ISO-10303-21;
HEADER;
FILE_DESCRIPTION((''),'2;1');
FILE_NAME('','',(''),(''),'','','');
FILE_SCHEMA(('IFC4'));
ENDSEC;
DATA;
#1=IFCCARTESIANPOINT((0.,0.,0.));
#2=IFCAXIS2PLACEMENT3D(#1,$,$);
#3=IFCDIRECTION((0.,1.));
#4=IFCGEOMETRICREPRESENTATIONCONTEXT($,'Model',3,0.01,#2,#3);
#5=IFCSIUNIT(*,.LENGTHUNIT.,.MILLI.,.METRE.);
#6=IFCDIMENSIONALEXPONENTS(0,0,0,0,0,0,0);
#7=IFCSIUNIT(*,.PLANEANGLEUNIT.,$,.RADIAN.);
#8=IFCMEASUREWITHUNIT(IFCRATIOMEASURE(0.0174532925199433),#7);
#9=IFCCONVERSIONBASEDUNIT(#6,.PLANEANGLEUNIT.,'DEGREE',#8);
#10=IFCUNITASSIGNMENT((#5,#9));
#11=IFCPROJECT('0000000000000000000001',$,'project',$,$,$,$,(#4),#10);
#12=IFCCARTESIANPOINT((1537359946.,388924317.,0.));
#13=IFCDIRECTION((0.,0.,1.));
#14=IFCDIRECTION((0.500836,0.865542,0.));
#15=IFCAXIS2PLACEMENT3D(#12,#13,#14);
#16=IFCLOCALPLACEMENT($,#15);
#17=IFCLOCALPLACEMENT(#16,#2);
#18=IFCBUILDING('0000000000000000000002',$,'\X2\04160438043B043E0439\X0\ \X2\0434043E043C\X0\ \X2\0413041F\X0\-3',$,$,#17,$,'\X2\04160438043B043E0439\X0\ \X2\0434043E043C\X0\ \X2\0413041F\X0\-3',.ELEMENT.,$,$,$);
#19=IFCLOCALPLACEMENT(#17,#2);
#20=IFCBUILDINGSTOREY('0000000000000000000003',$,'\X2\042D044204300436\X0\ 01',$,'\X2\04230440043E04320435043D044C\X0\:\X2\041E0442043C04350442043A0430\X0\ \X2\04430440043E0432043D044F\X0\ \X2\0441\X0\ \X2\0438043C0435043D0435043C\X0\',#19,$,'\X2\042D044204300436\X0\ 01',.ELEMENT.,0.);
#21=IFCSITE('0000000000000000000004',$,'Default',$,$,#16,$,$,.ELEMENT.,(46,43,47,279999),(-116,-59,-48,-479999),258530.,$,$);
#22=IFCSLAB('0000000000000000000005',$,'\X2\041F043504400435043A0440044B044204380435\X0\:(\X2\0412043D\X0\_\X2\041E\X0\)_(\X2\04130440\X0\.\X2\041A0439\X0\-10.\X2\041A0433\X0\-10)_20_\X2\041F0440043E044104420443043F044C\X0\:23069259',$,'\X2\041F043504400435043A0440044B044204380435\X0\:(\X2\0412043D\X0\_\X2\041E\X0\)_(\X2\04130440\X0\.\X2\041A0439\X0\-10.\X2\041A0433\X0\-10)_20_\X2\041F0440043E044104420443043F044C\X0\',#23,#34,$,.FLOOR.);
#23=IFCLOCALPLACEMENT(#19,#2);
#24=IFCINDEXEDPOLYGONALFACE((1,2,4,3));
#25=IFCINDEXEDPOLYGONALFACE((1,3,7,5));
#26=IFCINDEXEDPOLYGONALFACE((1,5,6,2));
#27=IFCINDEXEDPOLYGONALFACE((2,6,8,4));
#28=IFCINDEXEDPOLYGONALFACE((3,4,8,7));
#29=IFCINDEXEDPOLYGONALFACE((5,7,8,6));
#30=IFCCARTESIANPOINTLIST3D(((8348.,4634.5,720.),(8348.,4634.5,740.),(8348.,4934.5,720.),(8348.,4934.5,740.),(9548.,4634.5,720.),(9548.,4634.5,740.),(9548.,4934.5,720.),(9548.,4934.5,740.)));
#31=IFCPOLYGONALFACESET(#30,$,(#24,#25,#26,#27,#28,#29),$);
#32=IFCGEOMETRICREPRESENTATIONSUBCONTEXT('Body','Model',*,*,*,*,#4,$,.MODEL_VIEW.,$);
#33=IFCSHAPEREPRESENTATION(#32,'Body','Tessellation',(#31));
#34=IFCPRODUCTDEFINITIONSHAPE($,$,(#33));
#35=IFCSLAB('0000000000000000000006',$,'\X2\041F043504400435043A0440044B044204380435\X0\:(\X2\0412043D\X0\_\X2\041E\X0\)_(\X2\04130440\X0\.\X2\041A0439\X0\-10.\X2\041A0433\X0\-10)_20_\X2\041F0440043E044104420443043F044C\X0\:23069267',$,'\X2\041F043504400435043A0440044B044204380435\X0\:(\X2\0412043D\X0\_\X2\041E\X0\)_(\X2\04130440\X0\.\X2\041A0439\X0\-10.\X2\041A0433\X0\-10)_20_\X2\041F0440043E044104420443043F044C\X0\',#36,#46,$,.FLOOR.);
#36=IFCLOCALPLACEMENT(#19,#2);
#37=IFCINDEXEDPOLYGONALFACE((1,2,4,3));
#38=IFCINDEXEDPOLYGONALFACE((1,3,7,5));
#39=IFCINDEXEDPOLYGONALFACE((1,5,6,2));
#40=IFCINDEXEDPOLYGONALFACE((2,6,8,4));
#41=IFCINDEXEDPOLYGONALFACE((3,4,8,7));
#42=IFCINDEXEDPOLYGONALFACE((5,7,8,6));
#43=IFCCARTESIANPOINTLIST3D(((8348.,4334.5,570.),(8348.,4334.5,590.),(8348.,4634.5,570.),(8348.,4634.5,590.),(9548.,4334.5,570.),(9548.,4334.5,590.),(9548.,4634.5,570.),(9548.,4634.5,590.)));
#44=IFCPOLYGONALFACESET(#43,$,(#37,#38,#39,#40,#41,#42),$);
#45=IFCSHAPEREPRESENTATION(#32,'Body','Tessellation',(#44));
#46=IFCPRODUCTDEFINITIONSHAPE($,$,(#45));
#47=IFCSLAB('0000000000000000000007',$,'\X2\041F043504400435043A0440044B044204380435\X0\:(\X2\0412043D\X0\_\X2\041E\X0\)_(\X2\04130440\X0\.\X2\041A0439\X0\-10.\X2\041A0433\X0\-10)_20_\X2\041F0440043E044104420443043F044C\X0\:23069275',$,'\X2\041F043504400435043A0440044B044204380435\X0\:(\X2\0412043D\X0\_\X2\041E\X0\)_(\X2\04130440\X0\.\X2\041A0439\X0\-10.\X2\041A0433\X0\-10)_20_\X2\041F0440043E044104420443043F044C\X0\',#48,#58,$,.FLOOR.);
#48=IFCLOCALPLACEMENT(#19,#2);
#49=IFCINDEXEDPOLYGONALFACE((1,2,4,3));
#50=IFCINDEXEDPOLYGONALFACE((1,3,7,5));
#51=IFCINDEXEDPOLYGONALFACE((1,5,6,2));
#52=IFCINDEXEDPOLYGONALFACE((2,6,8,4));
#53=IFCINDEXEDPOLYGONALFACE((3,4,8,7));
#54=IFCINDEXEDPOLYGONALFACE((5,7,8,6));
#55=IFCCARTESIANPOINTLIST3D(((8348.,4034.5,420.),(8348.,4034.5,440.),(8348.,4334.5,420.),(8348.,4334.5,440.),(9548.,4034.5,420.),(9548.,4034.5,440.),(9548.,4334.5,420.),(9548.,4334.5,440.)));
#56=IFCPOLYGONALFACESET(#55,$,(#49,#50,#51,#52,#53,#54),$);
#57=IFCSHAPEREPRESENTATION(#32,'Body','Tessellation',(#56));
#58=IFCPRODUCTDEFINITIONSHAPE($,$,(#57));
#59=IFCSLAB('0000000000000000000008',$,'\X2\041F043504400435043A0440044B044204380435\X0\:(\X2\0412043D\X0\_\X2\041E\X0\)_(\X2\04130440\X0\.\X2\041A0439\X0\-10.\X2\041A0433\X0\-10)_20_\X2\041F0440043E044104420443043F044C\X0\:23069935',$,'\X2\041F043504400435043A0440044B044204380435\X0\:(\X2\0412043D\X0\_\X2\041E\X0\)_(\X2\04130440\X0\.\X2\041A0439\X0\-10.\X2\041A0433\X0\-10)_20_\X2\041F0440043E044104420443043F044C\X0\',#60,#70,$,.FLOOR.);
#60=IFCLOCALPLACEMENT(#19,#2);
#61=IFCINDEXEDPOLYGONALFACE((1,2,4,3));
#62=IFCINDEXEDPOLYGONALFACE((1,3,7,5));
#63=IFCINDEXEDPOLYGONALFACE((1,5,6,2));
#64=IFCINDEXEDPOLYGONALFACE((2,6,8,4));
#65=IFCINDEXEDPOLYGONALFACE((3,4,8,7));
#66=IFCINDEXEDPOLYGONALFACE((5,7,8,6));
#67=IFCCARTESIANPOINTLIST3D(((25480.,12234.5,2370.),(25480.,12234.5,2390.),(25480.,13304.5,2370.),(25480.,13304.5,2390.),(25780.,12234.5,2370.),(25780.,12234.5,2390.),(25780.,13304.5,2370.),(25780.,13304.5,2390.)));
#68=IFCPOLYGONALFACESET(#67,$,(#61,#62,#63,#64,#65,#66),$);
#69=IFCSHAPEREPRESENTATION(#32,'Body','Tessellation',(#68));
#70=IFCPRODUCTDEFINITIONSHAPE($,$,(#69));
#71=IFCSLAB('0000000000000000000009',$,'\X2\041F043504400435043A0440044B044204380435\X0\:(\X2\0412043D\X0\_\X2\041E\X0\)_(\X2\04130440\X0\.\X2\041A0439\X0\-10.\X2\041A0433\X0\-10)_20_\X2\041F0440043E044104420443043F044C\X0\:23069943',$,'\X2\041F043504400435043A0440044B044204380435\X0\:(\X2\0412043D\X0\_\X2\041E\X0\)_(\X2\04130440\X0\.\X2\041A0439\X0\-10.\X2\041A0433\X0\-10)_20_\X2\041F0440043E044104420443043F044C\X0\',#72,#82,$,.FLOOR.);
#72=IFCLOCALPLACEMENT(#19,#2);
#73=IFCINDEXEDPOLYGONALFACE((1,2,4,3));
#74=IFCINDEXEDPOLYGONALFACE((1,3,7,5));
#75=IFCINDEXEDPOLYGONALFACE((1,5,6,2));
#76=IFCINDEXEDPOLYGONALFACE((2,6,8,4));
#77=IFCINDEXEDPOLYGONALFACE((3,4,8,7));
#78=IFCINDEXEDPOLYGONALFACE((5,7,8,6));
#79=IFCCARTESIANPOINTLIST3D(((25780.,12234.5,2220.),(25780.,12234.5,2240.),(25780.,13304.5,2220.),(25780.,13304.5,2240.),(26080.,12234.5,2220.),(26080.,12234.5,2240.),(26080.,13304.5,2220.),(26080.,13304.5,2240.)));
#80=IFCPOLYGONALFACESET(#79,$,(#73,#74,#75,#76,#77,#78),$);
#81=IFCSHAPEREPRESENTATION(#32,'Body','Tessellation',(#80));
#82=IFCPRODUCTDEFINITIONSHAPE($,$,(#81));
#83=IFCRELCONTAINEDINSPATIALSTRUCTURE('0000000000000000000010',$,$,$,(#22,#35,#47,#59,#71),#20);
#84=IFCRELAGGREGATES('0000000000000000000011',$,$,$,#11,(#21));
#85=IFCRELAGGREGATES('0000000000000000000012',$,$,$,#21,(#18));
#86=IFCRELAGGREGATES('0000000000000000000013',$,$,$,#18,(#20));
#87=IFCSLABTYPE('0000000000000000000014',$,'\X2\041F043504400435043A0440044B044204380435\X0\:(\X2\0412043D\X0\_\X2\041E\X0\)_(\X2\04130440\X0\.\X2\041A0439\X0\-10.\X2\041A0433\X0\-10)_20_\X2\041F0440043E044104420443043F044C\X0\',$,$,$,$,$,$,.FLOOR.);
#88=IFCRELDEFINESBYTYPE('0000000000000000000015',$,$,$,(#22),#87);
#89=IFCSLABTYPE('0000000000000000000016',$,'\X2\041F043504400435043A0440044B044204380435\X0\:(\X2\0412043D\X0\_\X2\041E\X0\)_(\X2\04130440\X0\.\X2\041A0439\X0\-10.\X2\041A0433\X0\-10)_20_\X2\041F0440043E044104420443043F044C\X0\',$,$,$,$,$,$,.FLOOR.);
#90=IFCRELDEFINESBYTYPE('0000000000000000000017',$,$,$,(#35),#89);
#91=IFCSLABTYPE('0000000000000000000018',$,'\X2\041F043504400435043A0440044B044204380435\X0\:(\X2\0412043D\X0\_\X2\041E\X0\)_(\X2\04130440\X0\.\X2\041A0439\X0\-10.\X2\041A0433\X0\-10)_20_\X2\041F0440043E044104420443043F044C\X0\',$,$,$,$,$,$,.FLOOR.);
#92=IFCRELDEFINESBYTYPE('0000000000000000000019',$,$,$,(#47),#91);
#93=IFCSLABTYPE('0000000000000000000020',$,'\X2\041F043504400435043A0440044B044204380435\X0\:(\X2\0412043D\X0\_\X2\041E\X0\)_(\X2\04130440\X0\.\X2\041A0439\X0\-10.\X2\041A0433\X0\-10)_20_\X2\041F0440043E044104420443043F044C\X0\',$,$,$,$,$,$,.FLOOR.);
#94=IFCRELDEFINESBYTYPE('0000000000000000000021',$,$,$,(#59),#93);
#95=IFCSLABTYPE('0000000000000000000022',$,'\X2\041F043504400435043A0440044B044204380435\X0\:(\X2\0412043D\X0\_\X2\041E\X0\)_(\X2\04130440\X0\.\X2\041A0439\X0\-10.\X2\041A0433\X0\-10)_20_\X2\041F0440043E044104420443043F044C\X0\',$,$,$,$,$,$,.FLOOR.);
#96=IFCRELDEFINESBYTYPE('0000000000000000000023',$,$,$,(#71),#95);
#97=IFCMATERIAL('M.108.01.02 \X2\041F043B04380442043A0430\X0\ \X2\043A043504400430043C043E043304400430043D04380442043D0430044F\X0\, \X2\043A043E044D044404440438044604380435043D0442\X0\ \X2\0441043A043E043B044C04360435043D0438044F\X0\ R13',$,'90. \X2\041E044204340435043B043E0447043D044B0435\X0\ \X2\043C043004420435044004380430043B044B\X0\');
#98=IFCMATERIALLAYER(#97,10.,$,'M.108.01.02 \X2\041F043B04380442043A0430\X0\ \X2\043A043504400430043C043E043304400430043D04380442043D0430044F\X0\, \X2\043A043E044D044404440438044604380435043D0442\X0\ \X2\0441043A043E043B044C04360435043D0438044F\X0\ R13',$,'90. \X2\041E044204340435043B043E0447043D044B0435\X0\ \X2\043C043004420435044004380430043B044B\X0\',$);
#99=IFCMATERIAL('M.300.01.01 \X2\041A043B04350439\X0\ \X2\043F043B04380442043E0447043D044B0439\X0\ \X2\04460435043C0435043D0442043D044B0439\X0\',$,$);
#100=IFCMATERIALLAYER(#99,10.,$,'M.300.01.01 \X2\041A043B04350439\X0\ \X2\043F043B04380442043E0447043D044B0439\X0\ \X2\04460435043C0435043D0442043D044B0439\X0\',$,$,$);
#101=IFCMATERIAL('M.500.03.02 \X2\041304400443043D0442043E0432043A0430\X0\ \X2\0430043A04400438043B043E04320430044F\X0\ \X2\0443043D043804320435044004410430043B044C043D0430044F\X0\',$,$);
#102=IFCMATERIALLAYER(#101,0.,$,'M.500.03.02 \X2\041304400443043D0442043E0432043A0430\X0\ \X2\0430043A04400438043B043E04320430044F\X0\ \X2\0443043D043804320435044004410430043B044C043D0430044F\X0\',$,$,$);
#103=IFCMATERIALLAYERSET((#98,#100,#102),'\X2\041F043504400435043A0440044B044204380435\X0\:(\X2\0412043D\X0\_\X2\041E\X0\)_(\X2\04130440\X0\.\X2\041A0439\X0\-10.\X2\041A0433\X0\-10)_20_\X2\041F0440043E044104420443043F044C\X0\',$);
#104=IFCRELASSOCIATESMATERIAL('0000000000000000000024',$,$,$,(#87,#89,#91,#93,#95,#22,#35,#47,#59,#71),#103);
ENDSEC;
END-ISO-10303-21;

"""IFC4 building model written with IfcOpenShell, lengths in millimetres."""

from ifc_helpers import new_model, entity, si_unit, converted_unit, direction, frame, frame_2d, origin, origin_2d_with_axis, place, context, subcontext, project, spatial, rectangle, extrude, material, layer, layer_set, layer_usage, type_object, element, save


model = new_model("IFC4")

# Units and contexts
model_context = context("Model", 3, precision=0.01, world=origin(), true_north=direction((0.0, 1.0)))
body_context = subcontext(model_context, "Body", "Model", "MODEL_VIEW")
ifc_project = project(units=[si_unit("LENGTHUNIT", "METRE", prefix="MILLI"), converted_unit("PLANEANGLEUNIT", "DEGREE", entity("IfcRatioMeasure", 0.0174532925199433), si_unit("PLANEANGLEUNIT", "RADIAN"), dimensions=[0, 0, 0, 0, 0, 0, 0])], contexts=[model_context])

# Site, building, storey
site_placement = place(None, frame((1537359946.0, 388924317.0, 0.0), z_axis=(0.0, 0.0, 1.0), x_axis=(0.500836, 0.865542, 0.0)))
site = spatial("IfcSite", under=ifc_project, at=site_placement, Name="Default", CompositionType="ELEMENT", RefLatitude=(46, 43, 47, 279999), RefLongitude=(-116, -59, -48, -479999), RefElevation=258530.0)
building_placement = place(site_placement, origin())
building = spatial("IfcBuilding", under=site, at=building_placement, Name="Жилой дом ГП-3", LongName="Жилой дом ГП-3", CompositionType="ELEMENT")
storey_placement = place(building_placement, origin())
storey = spatial("IfcBuildingStorey", under=building, at=storey_placement, Name="Этаж 01", ObjectType="Уровень:Отметка уровня с именем", LongName="Этаж 01", CompositionType="ELEMENT", Elevation=0.0)

# Slabs
ifc_material_1 = material(Name="M.108.01.02 Плитка керамогранитная, коэффициент скольжения R13", Category="90. Отделочные материалы")
ifc_layer_1 = layer(ifc_material_1, 10.0, Name="M.108.01.02 Плитка керамогранитная, коэффициент скольжения R13", Category="90. Отделочные материалы")
ifc_material_2 = material(Name="M.300.01.01 Клей плиточный цементный")
ifc_layer_2 = layer(ifc_material_2, 10.0, Name="M.300.01.01 Клей плиточный цементный")
ifc_material_3 = material(Name="M.500.03.02 Грунтовка акриловая универсальная")
ifc_layer_3 = layer(ifc_material_3, 0.0, Name="M.500.03.02 Грунтовка акриловая универсальная")
ifc_layer_set_1 = layer_set([ifc_layer_1, ifc_layer_2, ifc_layer_3], Name="Перекрытие:(Вн_О)_(Гр.Кй-10.Кг-10)_20_Проступь")
ifc_layer_usage_1 = layer_usage(ifc_layer_set_1, "AXIS3", "POSITIVE", 0.0)
slab_type_1 = type_object("IfcSlabType", Name="Перекрытие:(Вн_О)_(Гр.Кй-10.Кг-10)_20_Проступь", PredefinedType="FLOOR", material=ifc_layer_set_1)
slab_1_placement = place(storey_placement, origin())
element("IfcSlab", 1, at=slab_1_placement, inside=storey, type_object=slab_type_1, material=ifc_layer_usage_1, Name="Перекрытие:(Вн_О)_(Гр.Кй-10.Кг-10)_20_Проступь:23069259", ObjectType="Перекрытие:(Вн_О)_(Гр.Кй-10.Кг-10)_20_Проступь", PredefinedType="FLOOR", context=body_context, shape_type="SweptSolid", body=[
    extrude(rectangle(XDim=300.0, YDim=1200.0, at=frame_2d((0.0, 0.0), x_axis=(1.0, 0.0))), frame((8948.0, 4784.5, 740.0), z_axis=(0.0, 0.0, -1.0), x_axis=(0.0, 1.0, 0.0)), (0.0, 0.0, 1.0), 20.0),
])
ifc_layer_usage_2 = layer_usage(ifc_layer_set_1, "AXIS3", "POSITIVE", 0.0)
slab_type_2 = type_object("IfcSlabType", Name="Перекрытие:(Вн_О)_(Гр.Кй-10.Кг-10)_20_Проступь", PredefinedType="FLOOR", material=ifc_layer_set_1)
slab_2_placement = place(storey_placement, origin())
element("IfcSlab", 2, at=slab_2_placement, inside=storey, type_object=slab_type_2, material=ifc_layer_usage_2, Name="Перекрытие:(Вн_О)_(Гр.Кй-10.Кг-10)_20_Проступь:23069267", ObjectType="Перекрытие:(Вн_О)_(Гр.Кй-10.Кг-10)_20_Проступь", PredefinedType="FLOOR", context=body_context, shape_type="SweptSolid", body=[
    extrude(rectangle(XDim=300.0, YDim=1200.0, at=origin_2d_with_axis()), frame((8948.0, 4484.5, 590.0), z_axis=(0.0, 0.0, -1.0), x_axis=(0.0, 1.0, 0.0)), (0.0, 0.0, 1.0), 20.0),
])
ifc_layer_usage_3 = layer_usage(ifc_layer_set_1, "AXIS3", "POSITIVE", 0.0)
slab_type_3 = type_object("IfcSlabType", Name="Перекрытие:(Вн_О)_(Гр.Кй-10.Кг-10)_20_Проступь", PredefinedType="FLOOR", material=ifc_layer_set_1)
slab_3_placement = place(storey_placement, origin())
element("IfcSlab", 3, at=slab_3_placement, inside=storey, type_object=slab_type_3, material=ifc_layer_usage_3, Name="Перекрытие:(Вн_О)_(Гр.Кй-10.Кг-10)_20_Проступь:23069275", ObjectType="Перекрытие:(Вн_О)_(Гр.Кй-10.Кг-10)_20_Проступь", PredefinedType="FLOOR", context=body_context, shape_type="SweptSolid", body=[
    extrude(rectangle(XDim=300.0, YDim=1200.0, at=origin_2d_with_axis()), frame((8948.0, 4184.5, 440.0), z_axis=(0.0, 0.0, -1.0), x_axis=(0.0, 1.0, 0.0)), (0.0, 0.0, 1.0), 20.0),
])
ifc_layer_usage_4 = layer_usage(ifc_layer_set_1, "AXIS3", "POSITIVE", 0.0)
slab_type_4 = type_object("IfcSlabType", Name="Перекрытие:(Вн_О)_(Гр.Кй-10.Кг-10)_20_Проступь", PredefinedType="FLOOR", material=ifc_layer_set_1)
slab_4_placement = place(storey_placement, origin())
element("IfcSlab", 4, at=slab_4_placement, inside=storey, type_object=slab_type_4, material=ifc_layer_usage_4, Name="Перекрытие:(Вн_О)_(Гр.Кй-10.Кг-10)_20_Проступь:23069935", ObjectType="Перекрытие:(Вн_О)_(Гр.Кй-10.Кг-10)_20_Проступь", PredefinedType="FLOOR", context=body_context, shape_type="SweptSolid", body=[
    extrude(rectangle(XDim=1070.0, YDim=300.0, at=frame_2d((0.0, 0.0), x_axis=(1.0, 0.0))), frame((25630.0, 12769.5, 2390.0), z_axis=(0.0, 0.0, -1.0), x_axis=(0.0, 1.0, 0.0)), (0.0, 0.0, 1.0), 20.0),
])
ifc_layer_usage_5 = layer_usage(ifc_layer_set_1, "AXIS3", "POSITIVE", 0.0)
slab_type_5 = type_object("IfcSlabType", Name="Перекрытие:(Вн_О)_(Гр.Кй-10.Кг-10)_20_Проступь", PredefinedType="FLOOR", material=ifc_layer_set_1)
slab_5_placement = place(storey_placement, origin())
element("IfcSlab", 5, at=slab_5_placement, inside=storey, type_object=slab_type_5, material=ifc_layer_usage_5, Name="Перекрытие:(Вн_О)_(Гр.Кй-10.Кг-10)_20_Проступь:23069943", ObjectType="Перекрытие:(Вн_О)_(Гр.Кй-10.Кг-10)_20_Проступь", PredefinedType="FLOOR", context=body_context, shape_type="SweptSolid", body=[
    extrude(rectangle(XDim=1070.0, YDim=300.0, at=frame_2d((0.0, 0.0), x_axis=(1.0, 0.0))), frame((25930.0, 12769.5, 2240.0), z_axis=(0.0, 0.0, -1.0), x_axis=(0.0, 1.0, 0.0)), (0.0, 0.0, 1.0), 20.0),
])

save(model, "model.ifc")
